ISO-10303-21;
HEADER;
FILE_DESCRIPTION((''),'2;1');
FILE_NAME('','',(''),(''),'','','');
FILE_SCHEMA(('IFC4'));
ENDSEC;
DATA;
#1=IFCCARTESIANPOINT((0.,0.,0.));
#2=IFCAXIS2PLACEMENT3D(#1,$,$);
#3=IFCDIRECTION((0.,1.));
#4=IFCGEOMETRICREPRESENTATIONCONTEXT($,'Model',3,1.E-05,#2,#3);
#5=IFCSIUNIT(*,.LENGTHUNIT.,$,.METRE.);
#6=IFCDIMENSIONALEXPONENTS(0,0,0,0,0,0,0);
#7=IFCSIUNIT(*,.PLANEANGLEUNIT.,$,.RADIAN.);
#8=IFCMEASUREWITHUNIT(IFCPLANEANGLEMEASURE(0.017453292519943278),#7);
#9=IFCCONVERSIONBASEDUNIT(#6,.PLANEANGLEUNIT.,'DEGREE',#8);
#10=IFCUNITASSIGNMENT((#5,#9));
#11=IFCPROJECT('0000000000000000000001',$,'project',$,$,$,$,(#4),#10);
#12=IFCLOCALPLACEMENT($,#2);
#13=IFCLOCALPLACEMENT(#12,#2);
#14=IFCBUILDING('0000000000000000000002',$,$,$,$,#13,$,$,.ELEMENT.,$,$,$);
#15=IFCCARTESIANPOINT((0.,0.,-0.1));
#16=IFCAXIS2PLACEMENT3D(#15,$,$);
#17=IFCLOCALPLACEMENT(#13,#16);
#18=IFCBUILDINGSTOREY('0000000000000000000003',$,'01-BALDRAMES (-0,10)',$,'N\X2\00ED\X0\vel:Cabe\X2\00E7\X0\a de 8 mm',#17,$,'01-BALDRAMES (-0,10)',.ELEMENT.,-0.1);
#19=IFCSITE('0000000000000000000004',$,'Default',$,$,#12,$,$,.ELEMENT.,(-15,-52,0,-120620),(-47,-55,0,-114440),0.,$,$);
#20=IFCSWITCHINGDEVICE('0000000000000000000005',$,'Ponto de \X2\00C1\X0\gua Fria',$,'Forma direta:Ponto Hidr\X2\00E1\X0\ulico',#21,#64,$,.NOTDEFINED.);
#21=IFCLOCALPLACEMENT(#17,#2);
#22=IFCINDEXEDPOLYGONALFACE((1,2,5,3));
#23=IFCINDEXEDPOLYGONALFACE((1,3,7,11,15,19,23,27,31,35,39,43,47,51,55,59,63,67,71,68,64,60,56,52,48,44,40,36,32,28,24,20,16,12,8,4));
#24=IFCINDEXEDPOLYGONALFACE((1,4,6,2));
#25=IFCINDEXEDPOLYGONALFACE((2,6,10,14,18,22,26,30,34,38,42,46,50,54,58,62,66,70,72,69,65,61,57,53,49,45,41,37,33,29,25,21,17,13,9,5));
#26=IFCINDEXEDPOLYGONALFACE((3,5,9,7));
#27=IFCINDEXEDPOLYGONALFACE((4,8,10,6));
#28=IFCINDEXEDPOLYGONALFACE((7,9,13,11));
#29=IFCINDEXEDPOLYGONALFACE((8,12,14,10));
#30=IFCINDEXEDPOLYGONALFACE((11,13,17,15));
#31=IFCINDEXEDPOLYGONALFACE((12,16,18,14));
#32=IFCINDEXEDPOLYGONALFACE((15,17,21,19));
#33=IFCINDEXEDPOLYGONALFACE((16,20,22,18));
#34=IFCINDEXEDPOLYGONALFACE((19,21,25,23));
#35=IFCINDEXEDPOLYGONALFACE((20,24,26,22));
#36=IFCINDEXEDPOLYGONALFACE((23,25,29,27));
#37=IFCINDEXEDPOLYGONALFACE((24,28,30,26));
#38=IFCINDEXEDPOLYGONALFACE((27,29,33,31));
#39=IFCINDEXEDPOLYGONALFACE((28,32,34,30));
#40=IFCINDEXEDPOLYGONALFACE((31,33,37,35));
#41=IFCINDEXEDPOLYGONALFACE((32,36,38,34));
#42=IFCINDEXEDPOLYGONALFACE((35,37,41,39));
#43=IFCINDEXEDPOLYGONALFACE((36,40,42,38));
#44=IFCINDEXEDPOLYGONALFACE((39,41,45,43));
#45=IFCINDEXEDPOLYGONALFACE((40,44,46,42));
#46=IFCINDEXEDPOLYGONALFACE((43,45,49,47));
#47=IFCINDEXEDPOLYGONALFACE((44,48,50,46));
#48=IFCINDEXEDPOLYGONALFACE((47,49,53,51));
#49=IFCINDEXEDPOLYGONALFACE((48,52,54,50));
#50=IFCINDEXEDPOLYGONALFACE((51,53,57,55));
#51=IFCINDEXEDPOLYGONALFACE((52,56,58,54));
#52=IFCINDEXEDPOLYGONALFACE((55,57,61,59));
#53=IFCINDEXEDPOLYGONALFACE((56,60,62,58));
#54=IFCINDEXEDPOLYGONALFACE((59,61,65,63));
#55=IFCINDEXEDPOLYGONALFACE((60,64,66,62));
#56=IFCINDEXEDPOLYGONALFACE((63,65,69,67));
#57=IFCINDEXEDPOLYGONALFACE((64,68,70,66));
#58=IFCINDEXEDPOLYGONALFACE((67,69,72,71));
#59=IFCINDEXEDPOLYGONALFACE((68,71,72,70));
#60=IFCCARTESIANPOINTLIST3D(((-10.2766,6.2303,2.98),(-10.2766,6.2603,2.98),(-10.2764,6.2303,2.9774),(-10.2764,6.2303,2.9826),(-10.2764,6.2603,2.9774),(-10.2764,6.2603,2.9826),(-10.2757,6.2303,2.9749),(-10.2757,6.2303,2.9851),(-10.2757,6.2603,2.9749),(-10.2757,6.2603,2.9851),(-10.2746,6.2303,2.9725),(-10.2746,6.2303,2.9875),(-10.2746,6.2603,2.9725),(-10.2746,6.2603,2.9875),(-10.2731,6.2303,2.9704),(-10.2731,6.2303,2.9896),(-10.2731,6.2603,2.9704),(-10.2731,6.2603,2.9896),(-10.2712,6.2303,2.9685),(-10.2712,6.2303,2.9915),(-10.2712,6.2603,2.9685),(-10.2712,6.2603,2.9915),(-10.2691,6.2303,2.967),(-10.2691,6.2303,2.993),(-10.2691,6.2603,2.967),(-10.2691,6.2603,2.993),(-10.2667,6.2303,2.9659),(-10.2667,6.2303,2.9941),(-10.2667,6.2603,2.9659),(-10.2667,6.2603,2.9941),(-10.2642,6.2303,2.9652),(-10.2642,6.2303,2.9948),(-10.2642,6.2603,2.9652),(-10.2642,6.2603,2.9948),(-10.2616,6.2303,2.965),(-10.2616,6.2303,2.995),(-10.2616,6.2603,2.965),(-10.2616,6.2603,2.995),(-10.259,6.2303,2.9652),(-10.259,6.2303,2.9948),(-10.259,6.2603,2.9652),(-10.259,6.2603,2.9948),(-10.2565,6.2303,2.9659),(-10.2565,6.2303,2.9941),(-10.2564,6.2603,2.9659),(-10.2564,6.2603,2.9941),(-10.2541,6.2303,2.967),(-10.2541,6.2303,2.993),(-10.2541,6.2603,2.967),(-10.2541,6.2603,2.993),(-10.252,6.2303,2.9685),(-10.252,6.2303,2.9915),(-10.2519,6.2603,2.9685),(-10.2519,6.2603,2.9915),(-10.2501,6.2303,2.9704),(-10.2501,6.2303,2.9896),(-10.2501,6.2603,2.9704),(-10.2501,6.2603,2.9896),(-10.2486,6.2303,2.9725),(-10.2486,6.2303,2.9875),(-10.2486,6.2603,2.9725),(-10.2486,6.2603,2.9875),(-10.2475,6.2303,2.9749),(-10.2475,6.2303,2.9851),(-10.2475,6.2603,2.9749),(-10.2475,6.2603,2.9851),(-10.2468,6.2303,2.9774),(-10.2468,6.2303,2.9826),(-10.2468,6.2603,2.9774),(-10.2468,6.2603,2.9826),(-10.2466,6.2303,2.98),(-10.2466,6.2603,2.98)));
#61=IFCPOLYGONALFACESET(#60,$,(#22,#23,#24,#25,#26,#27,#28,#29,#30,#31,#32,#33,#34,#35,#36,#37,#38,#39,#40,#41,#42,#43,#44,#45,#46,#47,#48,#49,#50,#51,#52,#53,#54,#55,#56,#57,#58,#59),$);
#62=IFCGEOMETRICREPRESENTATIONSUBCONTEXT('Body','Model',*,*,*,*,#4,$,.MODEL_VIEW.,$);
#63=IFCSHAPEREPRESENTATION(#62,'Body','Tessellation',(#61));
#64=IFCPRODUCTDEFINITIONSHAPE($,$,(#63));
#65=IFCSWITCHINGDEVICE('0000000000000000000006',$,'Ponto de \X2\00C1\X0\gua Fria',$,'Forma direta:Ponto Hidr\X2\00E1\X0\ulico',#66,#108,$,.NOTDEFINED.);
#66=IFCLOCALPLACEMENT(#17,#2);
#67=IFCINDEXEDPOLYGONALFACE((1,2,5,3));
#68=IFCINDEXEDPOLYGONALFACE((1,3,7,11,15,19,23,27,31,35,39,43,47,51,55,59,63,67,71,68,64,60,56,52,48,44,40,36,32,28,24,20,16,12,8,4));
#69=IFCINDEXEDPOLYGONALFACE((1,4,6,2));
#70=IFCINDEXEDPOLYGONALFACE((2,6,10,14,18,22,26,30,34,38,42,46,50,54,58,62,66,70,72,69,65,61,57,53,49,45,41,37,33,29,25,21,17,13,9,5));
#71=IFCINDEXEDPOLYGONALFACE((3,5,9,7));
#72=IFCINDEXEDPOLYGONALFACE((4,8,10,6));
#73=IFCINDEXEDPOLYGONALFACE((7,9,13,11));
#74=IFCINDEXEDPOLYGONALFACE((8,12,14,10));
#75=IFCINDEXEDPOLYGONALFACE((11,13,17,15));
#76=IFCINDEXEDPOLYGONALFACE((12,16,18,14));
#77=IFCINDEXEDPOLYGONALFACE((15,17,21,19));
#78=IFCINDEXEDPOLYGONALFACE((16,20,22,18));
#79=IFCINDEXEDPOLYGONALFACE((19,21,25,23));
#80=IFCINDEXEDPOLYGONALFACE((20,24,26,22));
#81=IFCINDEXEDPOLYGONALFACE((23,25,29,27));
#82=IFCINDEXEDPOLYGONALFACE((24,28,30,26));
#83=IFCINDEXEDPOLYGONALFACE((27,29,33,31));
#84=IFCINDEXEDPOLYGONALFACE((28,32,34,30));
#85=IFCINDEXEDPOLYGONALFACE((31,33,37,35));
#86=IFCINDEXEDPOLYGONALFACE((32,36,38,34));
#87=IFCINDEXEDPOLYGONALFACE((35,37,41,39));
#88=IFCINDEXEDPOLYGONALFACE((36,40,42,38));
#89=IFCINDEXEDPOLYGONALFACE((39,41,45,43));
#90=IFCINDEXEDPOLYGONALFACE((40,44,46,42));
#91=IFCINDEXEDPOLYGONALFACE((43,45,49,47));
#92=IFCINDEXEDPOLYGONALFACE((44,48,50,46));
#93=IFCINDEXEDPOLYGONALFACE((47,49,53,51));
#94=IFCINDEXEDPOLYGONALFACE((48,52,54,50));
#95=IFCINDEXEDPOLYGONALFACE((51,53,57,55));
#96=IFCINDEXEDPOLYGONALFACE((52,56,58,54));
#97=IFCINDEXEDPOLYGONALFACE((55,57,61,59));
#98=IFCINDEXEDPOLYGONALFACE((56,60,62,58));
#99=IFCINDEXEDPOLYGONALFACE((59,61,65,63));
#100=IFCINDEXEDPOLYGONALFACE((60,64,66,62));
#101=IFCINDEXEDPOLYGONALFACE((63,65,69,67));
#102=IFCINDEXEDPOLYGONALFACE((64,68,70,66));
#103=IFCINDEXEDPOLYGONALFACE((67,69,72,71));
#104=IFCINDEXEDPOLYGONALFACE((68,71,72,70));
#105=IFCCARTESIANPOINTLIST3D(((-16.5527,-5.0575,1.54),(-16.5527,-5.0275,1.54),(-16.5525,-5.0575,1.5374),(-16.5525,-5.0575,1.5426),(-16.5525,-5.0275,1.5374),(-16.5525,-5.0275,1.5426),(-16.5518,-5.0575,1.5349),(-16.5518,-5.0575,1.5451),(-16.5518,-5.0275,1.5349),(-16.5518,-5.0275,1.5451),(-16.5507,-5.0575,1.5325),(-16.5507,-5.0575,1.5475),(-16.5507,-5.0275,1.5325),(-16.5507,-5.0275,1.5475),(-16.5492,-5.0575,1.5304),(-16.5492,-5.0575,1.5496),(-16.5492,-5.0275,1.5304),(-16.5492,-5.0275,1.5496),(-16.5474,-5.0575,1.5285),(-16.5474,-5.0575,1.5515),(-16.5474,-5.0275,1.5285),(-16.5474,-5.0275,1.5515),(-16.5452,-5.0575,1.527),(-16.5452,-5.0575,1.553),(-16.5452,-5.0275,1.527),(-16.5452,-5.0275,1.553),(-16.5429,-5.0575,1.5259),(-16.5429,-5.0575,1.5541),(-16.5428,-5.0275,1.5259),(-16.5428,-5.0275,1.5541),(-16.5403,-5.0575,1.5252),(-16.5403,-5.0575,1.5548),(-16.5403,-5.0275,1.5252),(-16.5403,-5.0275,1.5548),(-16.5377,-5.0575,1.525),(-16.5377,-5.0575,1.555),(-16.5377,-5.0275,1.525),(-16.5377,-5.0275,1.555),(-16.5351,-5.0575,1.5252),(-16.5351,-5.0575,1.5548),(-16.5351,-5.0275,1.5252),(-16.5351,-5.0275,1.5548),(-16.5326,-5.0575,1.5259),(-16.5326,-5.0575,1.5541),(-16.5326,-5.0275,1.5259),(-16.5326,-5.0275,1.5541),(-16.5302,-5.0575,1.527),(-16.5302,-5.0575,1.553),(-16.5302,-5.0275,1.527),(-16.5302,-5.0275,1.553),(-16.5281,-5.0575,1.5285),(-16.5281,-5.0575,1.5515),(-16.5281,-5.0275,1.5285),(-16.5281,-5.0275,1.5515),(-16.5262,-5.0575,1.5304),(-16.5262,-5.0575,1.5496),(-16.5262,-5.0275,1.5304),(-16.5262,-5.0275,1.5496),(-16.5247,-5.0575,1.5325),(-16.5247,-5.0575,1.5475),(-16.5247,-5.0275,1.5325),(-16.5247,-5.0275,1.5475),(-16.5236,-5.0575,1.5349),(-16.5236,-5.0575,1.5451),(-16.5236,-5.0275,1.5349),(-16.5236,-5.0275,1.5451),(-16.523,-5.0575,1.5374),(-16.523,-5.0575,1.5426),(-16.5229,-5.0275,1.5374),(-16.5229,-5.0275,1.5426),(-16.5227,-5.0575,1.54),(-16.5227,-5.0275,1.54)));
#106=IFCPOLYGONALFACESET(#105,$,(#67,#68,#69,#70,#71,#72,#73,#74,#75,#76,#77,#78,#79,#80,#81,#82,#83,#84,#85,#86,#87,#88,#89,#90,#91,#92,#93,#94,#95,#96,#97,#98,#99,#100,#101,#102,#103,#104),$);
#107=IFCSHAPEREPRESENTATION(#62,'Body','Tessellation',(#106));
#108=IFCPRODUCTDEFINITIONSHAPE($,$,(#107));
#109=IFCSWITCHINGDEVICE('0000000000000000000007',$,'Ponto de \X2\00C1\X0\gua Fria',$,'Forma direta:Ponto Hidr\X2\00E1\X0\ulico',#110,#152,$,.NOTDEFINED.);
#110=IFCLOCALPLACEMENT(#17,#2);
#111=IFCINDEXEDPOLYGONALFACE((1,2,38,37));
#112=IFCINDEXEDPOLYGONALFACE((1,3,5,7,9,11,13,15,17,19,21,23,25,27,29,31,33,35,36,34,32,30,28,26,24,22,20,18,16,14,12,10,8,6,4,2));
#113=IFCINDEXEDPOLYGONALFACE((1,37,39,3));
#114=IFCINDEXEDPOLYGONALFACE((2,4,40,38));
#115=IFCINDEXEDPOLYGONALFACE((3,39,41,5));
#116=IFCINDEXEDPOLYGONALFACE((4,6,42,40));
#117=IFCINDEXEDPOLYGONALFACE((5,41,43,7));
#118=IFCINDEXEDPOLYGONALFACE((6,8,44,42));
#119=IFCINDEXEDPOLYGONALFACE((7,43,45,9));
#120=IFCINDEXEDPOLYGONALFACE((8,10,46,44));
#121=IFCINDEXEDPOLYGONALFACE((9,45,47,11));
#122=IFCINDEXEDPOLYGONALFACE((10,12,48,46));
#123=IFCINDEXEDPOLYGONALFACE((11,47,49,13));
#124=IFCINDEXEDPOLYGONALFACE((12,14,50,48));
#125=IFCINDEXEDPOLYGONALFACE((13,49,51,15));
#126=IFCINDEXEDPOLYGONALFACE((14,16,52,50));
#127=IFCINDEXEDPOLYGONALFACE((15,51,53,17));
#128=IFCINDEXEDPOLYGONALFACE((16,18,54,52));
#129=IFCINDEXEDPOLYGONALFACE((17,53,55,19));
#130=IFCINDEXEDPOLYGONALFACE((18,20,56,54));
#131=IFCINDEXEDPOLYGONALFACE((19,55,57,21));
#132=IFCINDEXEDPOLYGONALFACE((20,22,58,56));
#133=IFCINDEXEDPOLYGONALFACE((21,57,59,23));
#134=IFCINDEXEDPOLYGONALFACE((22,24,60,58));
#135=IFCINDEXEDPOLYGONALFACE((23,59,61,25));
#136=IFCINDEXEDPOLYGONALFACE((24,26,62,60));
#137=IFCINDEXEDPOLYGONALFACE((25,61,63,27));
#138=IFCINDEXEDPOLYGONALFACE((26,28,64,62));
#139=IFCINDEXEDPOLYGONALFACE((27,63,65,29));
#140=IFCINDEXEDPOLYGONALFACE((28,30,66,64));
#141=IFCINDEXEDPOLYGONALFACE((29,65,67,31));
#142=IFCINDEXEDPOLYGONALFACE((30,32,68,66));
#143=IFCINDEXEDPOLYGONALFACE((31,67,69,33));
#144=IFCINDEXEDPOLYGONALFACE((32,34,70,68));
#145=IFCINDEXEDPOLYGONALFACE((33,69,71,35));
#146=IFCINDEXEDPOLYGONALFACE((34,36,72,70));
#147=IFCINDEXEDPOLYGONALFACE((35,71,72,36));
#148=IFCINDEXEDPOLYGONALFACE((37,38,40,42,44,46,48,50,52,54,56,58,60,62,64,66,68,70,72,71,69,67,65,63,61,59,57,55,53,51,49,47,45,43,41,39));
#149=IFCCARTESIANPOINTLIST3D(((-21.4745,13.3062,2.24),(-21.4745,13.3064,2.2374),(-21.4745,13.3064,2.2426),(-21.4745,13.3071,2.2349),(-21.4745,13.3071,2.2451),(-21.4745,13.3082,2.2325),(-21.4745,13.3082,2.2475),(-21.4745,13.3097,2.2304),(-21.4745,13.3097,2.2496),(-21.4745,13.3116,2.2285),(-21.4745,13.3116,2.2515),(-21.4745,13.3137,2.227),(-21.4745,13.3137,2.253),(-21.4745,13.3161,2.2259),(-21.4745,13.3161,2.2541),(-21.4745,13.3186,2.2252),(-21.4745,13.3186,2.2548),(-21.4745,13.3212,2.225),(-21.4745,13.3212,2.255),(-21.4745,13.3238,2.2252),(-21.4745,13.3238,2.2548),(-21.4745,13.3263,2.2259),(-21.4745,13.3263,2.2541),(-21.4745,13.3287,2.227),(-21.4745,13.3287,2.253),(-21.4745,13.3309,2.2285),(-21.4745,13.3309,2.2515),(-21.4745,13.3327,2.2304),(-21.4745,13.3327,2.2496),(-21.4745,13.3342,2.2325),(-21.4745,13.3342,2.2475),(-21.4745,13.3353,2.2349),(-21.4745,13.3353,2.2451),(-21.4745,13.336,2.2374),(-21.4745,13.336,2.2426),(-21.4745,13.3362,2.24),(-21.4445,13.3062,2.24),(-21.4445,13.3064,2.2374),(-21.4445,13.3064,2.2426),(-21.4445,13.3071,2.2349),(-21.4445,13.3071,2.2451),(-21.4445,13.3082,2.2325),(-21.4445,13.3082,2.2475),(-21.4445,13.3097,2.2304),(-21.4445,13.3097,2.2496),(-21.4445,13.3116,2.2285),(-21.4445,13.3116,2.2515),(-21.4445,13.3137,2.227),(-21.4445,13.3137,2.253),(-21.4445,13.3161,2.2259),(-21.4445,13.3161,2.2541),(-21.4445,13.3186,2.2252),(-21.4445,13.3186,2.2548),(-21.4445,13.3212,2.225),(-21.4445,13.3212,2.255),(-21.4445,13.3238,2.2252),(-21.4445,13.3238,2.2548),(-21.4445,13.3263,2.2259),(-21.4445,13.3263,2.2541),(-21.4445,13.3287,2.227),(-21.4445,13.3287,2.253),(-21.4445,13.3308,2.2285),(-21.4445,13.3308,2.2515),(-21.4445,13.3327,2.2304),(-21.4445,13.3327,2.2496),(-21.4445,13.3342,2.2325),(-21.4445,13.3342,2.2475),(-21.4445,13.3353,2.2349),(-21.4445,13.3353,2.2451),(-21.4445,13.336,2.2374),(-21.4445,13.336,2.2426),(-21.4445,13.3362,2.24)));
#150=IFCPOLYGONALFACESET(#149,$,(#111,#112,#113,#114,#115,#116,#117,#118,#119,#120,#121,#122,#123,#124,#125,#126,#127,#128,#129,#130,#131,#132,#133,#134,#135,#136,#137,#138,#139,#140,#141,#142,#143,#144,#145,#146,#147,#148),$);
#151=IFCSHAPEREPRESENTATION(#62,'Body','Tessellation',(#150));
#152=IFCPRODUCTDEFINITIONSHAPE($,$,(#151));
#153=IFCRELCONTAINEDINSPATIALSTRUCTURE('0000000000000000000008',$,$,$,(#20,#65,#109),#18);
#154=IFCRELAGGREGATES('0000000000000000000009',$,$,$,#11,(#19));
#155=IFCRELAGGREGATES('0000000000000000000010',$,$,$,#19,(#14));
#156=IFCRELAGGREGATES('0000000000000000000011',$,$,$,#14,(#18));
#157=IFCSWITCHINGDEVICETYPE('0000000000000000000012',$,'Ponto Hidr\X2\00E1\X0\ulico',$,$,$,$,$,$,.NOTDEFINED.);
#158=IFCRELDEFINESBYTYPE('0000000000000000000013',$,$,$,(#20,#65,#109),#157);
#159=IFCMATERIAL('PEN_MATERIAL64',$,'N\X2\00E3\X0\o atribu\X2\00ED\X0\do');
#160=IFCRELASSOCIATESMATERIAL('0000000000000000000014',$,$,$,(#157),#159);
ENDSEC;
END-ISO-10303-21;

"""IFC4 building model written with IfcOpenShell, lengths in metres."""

from ifc_helpers import new_model, entity, si_unit, converted_unit, direction, frame, origin, place, context, subcontext, project, spatial, indexed_curve, outline, extrude, material, type_object, element, save


model = new_model("IFC4")

# Units and contexts
model_context = context("Model", 3, precision=1e-05, world=origin(), true_north=direction((0.0, 1.0)))
body_context = subcontext(model_context, "Body", "Model", "MODEL_VIEW")
ifc_project = project(units=[si_unit("LENGTHUNIT", "METRE"), converted_unit("PLANEANGLEUNIT", "DEGREE", entity("IfcPlaneAngleMeasure", 0.017453292519943278), si_unit("PLANEANGLEUNIT", "RADIAN"), dimensions=[0, 0, 0, 0, 0, 0, 0])], contexts=[model_context])

# Site, building, storey
site_placement = place(None, origin())
site = spatial("IfcSite", under=ifc_project, at=site_placement, Name="Default", CompositionType="ELEMENT", RefLatitude=(-15, -52, 0, -120620), RefLongitude=(-47, -55, 0, -114440), RefElevation=0.0)
building_placement = place(site_placement, origin())
building = spatial("IfcBuilding", under=site, at=building_placement, CompositionType="ELEMENT")
storey_placement = place(building_placement, frame((0.0, 0.0, -0.1)))
storey = spatial("IfcBuildingStorey", under=building, at=storey_placement, Name="01-BALDRAMES (-0,10)", ObjectType="Nível:Cabeça de 8 mm", LongName="01-BALDRAMES (-0,10)", CompositionType="ELEMENT", Elevation=-0.1)

# Switching devices
ifc_material_1 = material(Name="PEN_MATERIAL64", Category="Não atribuído")
switching_device_type = type_object("IfcSwitchingDeviceType", Name="Ponto Hidráulico", PredefinedType="NOTDEFINED", material=ifc_material_1)
switching_device_1_placement = place(storey_placement, origin())
element("IfcSwitchingDevice", 1, at=switching_device_1_placement, inside=storey, type_object=switching_device_type, Name="Ponto de Água Fria", ObjectType="Forma direta:Ponto Hidráulico", PredefinedType="NOTDEFINED", context=body_context, shape_type="SweptSolid", body=[
    extrude(outline(indexed_curve([(-0.0013, -0.0149), (0.0013, -0.0149), (0.0039, -0.0145), (0.0063, -0.0136), (0.0086, -0.0123), (0.0106, -0.0106), (0.0123, -0.0086), (0.0136, -0.0063), (0.0145, -0.0039), (0.0149, -0.0013), (0.0149, 0.0013), (0.0145, 0.0039), (0.0136, 0.0063), (0.0123, 0.0086), (0.0106, 0.0106), (0.0086, 0.0123), (0.0063, 0.0136), (0.0039, 0.0145), (0.0013, 0.0149), (-0.0013, 0.0149), (-0.0039, 0.0145), (-0.0063, 0.0136), (-0.0086, 0.0123), (-0.0106, 0.0106), (-0.0123, 0.0086), (-0.0136, 0.0063), (-0.0145, 0.0039), (-0.0149, 0.0013), (-0.0149, -0.0013), (-0.0145, -0.0039), (-0.0136, -0.0063), (-0.0123, -0.0086), (-0.0106, -0.0106), (-0.0086, -0.0123), (-0.0063, -0.0136), (-0.0039, -0.0145), (-0.0013, -0.0149)], self_intersect=False)), frame((-10.2616, 6.2303, 2.98), z_axis=(0.000435, 1.0, 0.0), x_axis=(-0.965926, 0.00042, 0.258819)), (0.0, 0.0, 1.0), 0.03),
])
switching_device_2_placement = place(storey_placement, origin())
element("IfcSwitchingDevice", 2, at=switching_device_2_placement, inside=storey, type_object=switching_device_type, Name="Ponto de Água Fria", ObjectType="Forma direta:Ponto Hidráulico", PredefinedType="NOTDEFINED", context=body_context, shape_type="SweptSolid", body=[
    extrude(outline(indexed_curve([(-0.0013, -0.0149), (0.0013, -0.0149), (0.0039, -0.0145), (0.0063, -0.0136), (0.0086, -0.0123), (0.0106, -0.0106), (0.0123, -0.0086), (0.0136, -0.0063), (0.0145, -0.0039), (0.0149, -0.0013), (0.0149, 0.0013), (0.0145, 0.0039), (0.0136, 0.0063), (0.0123, 0.0086), (0.0106, 0.0106), (0.0086, 0.0123), (0.0063, 0.0136), (0.0039, 0.0145), (0.0013, 0.0149), (-0.0013, 0.0149), (-0.0039, 0.0145), (-0.0063, 0.0136), (-0.0086, 0.0123), (-0.0106, 0.0106), (-0.0123, 0.0086), (-0.0136, 0.0063), (-0.0145, 0.0039), (-0.0149, 0.0013), (-0.0149, -0.0013), (-0.0145, -0.0039), (-0.0136, -0.0063), (-0.0123, -0.0086), (-0.0106, -0.0106), (-0.0086, -0.0123), (-0.0063, -0.0136), (-0.0039, -0.0145), (-0.0013, -0.0149)], self_intersect=False)), frame((-16.5377, -5.0575, 1.54), z_axis=(0.000435, 1.0, 0.0), x_axis=(-0.965926, 0.00042, 0.258819)), (0.0, 0.0, 1.0), 0.03),
])
switching_device_3_placement = place(storey_placement, origin())
element("IfcSwitchingDevice", 3, at=switching_device_3_placement, inside=storey, type_object=switching_device_type, Name="Ponto de Água Fria", ObjectType="Forma direta:Ponto Hidráulico", PredefinedType="NOTDEFINED", context=body_context, shape_type="SweptSolid", body=[
    extrude(outline(indexed_curve([(-0.0013, -0.0149), (0.0013, -0.0149), (0.0039, -0.0145), (0.0063, -0.0136), (0.0086, -0.0123), (0.0106, -0.0106), (0.0123, -0.0086), (0.0136, -0.0063), (0.0145, -0.0039), (0.0149, -0.0013), (0.0149, 0.0013), (0.0145, 0.0039), (0.0136, 0.0063), (0.0123, 0.0086), (0.0106, 0.0106), (0.0086, 0.0123), (0.0063, 0.0136), (0.0039, 0.0145), (0.0013, 0.0149), (-0.0013, 0.0149), (-0.0039, 0.0145), (-0.0063, 0.0136), (-0.0086, 0.0123), (-0.0106, 0.0106), (-0.0123, 0.0086), (-0.0136, 0.0063), (-0.0145, 0.0039), (-0.0149, 0.0013), (-0.0149, -0.0013), (-0.0145, -0.0039), (-0.0136, -0.0063), (-0.0123, -0.0086), (-0.0106, -0.0106), (-0.0086, -0.0123), (-0.0063, -0.0136), (-0.0039, -0.0145), (-0.0013, -0.0149)], self_intersect=False)), frame((-21.4745, 13.3212, 2.24), z_axis=(1.0, -0.000435, 0.0), x_axis=(0.000433, 0.996195, -0.087156)), (0.0, 0.0, 1.0), 0.03),
])

save(model, "model.ifc")
